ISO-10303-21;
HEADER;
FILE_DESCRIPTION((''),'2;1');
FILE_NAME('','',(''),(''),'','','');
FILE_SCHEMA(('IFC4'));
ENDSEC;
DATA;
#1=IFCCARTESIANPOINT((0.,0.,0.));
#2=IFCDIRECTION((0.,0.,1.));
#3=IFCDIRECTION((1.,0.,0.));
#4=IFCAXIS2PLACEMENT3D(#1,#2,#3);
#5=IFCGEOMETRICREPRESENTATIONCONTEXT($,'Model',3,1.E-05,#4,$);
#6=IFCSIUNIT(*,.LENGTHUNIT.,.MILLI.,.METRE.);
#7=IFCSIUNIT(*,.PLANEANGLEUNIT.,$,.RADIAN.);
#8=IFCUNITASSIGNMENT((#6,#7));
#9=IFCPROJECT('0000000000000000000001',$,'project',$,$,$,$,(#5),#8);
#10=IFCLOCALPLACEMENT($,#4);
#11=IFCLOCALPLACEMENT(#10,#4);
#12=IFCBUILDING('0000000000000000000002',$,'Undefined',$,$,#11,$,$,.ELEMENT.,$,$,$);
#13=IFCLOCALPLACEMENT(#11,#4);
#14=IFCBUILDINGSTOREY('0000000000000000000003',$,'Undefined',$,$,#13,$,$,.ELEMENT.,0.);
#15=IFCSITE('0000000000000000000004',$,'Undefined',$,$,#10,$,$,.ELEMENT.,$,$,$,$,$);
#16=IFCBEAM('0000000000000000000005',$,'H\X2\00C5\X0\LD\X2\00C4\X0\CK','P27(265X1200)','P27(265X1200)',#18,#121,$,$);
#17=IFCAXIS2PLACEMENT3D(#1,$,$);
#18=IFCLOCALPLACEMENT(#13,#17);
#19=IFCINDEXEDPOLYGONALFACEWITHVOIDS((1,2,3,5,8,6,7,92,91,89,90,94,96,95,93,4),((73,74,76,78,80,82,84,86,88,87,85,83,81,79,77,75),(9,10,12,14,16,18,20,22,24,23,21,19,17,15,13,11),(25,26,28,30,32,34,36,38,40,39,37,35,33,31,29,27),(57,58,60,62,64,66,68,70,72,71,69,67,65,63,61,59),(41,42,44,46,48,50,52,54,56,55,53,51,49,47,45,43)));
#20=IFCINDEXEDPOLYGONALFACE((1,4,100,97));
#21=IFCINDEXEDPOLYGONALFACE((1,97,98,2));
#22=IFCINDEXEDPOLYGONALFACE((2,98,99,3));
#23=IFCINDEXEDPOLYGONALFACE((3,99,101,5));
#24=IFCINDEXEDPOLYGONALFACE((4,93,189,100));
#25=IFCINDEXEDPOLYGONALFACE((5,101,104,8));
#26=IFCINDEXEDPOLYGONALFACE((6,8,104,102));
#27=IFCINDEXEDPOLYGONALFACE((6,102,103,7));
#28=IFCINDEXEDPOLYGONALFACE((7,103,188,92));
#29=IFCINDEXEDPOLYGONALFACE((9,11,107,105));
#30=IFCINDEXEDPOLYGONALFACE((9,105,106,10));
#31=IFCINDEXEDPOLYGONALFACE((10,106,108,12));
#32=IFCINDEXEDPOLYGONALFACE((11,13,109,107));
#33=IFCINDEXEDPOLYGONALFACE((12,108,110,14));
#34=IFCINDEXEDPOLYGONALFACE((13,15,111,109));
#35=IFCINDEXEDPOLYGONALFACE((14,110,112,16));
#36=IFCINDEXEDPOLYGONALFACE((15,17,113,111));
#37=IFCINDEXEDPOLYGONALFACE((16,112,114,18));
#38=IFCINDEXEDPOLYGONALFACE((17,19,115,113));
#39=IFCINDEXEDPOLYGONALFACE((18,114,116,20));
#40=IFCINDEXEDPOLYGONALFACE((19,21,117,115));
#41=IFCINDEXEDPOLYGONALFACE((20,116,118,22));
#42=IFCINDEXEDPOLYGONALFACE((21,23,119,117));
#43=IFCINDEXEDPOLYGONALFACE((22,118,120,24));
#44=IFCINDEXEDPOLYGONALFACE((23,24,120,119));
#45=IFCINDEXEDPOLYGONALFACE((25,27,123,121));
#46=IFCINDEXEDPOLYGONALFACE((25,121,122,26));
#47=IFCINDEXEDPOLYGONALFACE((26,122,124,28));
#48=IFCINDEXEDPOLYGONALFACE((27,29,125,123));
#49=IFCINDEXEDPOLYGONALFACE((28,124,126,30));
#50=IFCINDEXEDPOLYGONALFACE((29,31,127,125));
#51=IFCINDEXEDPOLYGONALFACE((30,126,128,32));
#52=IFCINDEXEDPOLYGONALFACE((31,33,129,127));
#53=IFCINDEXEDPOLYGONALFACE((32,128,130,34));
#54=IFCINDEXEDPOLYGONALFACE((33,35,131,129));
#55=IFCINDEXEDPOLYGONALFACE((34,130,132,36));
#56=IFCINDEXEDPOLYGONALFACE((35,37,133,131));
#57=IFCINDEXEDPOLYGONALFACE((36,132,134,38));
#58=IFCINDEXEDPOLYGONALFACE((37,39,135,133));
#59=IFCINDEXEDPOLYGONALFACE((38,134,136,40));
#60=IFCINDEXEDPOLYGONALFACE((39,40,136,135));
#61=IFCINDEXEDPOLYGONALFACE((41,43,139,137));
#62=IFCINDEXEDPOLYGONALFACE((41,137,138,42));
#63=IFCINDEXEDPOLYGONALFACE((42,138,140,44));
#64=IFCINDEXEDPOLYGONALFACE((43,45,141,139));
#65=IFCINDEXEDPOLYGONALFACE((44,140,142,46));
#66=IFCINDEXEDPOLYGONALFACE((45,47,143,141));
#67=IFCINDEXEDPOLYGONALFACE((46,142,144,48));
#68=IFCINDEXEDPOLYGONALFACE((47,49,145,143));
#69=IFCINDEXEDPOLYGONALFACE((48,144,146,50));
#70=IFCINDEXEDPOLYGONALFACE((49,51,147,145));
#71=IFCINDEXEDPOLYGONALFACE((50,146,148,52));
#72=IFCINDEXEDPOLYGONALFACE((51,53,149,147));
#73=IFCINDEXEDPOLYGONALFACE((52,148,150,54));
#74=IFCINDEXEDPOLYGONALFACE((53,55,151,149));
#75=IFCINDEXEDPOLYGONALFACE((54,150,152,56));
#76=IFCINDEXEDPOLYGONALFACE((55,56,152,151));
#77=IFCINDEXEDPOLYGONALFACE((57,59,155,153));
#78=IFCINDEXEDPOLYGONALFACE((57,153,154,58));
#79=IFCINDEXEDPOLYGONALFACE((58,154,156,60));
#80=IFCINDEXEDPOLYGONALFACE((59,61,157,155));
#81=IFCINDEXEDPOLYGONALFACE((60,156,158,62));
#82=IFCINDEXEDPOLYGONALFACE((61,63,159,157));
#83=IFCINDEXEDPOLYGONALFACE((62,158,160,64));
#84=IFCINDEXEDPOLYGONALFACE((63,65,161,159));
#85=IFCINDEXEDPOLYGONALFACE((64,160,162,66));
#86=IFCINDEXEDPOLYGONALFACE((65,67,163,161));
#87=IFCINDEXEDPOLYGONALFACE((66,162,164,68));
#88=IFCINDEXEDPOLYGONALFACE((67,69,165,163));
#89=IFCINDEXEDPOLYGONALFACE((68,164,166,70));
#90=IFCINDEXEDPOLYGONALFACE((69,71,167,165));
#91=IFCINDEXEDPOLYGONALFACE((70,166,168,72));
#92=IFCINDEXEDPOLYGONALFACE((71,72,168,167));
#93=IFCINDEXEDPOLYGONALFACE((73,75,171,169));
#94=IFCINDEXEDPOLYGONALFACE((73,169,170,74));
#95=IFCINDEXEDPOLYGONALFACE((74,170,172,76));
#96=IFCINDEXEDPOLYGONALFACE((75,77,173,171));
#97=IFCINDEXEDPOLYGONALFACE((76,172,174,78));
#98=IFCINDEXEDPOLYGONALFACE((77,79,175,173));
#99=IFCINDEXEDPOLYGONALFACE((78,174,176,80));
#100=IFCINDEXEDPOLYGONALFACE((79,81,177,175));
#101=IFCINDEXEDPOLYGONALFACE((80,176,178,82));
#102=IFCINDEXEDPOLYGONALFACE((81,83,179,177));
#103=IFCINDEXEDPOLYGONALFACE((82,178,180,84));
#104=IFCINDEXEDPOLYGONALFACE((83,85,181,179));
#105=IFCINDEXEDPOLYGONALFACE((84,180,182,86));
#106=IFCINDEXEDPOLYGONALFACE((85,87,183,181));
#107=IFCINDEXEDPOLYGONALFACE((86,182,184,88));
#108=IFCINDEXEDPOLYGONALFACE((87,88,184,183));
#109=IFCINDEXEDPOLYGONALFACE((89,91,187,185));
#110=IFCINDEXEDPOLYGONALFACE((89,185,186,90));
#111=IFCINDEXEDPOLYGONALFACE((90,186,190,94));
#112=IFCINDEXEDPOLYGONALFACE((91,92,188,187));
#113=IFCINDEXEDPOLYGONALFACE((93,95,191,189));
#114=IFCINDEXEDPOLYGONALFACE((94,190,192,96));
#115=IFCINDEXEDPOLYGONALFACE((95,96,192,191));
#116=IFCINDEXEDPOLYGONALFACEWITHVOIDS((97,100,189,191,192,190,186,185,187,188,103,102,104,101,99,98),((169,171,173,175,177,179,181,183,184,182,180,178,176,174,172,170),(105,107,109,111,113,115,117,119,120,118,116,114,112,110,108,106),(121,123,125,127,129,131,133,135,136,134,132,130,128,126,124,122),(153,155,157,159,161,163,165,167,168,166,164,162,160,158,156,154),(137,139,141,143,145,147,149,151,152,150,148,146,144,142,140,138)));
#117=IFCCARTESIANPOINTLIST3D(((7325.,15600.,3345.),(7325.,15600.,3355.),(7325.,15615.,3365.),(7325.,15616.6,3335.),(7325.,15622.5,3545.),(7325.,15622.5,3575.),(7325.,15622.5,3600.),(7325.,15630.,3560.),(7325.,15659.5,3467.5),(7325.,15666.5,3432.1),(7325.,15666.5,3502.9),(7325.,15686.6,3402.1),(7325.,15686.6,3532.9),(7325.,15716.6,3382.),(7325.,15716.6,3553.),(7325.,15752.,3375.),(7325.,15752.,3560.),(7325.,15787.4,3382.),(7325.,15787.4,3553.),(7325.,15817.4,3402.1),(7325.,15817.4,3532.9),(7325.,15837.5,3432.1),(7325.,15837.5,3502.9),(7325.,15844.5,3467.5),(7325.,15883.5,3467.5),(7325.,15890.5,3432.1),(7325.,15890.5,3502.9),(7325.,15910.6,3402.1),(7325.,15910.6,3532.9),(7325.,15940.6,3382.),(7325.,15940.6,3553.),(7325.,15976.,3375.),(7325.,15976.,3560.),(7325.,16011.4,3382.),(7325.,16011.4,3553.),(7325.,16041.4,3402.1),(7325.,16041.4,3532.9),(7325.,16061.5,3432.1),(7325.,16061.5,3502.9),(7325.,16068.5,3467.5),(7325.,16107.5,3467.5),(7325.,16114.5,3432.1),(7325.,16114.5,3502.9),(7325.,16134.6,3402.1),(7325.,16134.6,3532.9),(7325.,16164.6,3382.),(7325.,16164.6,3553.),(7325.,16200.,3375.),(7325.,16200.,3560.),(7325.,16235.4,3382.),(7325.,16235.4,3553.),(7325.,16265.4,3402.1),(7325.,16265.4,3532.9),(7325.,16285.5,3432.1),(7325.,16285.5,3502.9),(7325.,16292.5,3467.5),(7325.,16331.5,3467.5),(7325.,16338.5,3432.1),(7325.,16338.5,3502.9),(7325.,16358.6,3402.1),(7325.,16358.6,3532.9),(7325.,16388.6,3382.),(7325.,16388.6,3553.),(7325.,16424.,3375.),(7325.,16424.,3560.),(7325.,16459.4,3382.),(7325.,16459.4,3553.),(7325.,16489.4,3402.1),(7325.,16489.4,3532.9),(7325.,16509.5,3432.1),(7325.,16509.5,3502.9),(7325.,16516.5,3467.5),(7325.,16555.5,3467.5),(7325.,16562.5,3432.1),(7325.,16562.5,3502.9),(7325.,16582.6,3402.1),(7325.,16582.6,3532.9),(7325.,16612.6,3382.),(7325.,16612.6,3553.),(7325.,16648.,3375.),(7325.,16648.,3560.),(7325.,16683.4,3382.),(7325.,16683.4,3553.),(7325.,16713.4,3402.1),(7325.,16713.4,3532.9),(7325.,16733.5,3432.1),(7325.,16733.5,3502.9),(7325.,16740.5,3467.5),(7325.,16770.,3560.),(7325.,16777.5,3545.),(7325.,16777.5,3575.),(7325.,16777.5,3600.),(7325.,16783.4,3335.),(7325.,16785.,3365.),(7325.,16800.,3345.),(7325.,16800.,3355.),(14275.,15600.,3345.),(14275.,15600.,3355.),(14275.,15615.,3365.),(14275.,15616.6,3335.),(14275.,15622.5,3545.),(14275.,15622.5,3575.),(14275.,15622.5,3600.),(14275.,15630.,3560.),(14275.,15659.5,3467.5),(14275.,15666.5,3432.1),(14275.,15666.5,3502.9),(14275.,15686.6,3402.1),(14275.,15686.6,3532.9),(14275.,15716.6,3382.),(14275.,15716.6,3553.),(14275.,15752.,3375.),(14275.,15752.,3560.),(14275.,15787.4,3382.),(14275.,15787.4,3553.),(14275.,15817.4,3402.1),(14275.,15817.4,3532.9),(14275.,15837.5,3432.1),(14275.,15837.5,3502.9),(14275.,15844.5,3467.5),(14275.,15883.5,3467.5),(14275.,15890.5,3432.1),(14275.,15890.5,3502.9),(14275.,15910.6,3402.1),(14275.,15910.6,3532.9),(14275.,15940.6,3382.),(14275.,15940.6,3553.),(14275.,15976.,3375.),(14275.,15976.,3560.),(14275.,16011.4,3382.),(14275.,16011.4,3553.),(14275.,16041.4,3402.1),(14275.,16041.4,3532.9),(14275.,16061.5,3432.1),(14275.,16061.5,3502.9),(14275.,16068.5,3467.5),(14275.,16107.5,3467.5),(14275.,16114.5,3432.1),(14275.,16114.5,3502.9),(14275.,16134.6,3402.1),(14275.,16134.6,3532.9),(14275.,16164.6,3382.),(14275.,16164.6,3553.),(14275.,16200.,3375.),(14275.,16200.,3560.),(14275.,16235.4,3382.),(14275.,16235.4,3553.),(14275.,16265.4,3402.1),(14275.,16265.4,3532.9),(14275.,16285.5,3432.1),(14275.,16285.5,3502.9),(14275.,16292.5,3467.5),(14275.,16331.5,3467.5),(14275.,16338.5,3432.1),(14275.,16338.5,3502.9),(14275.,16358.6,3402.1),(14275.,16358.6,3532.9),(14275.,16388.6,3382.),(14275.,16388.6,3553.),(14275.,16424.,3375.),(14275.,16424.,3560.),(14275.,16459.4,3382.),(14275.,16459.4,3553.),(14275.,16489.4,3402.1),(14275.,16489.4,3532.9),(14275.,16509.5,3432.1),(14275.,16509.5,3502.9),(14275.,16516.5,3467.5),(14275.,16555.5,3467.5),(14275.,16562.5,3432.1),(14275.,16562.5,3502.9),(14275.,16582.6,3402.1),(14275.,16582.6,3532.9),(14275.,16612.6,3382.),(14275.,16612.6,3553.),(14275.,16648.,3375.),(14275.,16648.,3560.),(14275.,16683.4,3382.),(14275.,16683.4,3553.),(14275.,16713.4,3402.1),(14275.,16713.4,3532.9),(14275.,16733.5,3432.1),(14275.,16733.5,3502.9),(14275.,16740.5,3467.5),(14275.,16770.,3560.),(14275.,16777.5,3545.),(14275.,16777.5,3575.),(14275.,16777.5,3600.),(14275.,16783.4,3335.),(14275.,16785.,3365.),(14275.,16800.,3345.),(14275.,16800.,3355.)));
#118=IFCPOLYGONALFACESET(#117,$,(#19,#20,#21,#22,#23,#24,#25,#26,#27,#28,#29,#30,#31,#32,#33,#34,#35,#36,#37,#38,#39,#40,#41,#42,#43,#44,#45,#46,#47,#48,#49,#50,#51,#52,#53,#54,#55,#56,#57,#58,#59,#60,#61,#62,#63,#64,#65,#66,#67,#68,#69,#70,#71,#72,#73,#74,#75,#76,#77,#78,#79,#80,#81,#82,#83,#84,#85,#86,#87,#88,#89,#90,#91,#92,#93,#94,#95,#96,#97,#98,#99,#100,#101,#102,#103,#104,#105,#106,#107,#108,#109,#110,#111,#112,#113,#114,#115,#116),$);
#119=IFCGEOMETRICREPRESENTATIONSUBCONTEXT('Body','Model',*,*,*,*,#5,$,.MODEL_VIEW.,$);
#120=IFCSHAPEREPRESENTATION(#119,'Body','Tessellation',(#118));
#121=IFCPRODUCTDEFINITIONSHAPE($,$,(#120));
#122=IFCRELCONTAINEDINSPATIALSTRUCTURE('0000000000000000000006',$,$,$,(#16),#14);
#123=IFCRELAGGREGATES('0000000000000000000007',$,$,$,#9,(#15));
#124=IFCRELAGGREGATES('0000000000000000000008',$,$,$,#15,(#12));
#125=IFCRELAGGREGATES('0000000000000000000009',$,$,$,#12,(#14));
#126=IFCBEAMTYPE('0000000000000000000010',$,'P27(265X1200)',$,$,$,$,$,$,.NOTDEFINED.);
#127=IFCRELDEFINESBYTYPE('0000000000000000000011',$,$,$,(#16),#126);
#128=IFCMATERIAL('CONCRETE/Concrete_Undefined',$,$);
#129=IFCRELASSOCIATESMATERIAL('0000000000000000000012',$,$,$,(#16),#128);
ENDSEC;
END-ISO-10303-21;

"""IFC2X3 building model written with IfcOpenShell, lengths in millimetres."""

from ifc_helpers import new_model, si_unit, frame, origin_with_axes, place, context, subcontext, project, spatial, polyline, outline, extrude, material, type_object, element, save


model = new_model("IFC2X3")

# Units and contexts
model_context = context("Model", 3, precision=1e-05, world=origin_with_axes())
body_context = subcontext(model_context, "Body", "Model", "MODEL_VIEW")
ifc_project = project(units=[si_unit("LENGTHUNIT", "METRE", prefix="MILLI"), si_unit("PLANEANGLEUNIT", "RADIAN")], contexts=[model_context])

# Site, building, storey
site_placement = place(None, origin_with_axes())
site = spatial("IfcSite", under=ifc_project, at=site_placement, Name="Undefined", CompositionType="ELEMENT")
building_placement = place(site_placement, origin_with_axes())
building = spatial("IfcBuilding", under=site, at=building_placement, Name="Undefined", CompositionType="ELEMENT")
storey_placement = place(building_placement, origin_with_axes())
storey = spatial("IfcBuildingStorey", under=building, at=storey_placement, Name="Undefined", CompositionType="ELEMENT", Elevation=0.0)

# Beam
ifc_material_1 = material(Name="CONCRETE/Concrete_Undefined")
beam_type_1 = type_object("IfcBeamType", Name="P27(265X1200)", PredefinedType="NOTDEFINED")
beam_1_placement = place(storey_placement, frame((7325.0, 16200.0, 3467.5), z_axis=(0.0, 0.0, 1.0), x_axis=(1.0, 0.0, 0.0)))
element("IfcBeam", 1, at=beam_1_placement, inside=storey, type_object=beam_type_1, material=ifc_material_1, Name="HÅLDÄCK", Description="P27(265X1200)", ObjectType="P27(265X1200)", context=body_context, shape_type="SweptSolid", body=[
    extrude(outline(polyline([(-583.4, -132.5), (-600.0, -122.5), (-600.0, -112.5), (-585.0, -102.5), (-577.5, 77.5), (-570.0, 92.5), (-577.5, 107.5), (-577.5, 132.5), (577.5, 132.5), (577.5, 107.5), (570.0, 92.5), (577.5, 77.5), (585.0, -102.5), (600.0, -112.5), (600.0, -122.5), (583.4, -132.5), (-583.4, -132.5)]), holes=[polyline([(-513.4, 65.4), (-533.5, 35.4), (-540.5, 0.0), (-533.5, -35.4), (-513.4, -65.4), (-483.4, -85.5), (-448.0, -92.5), (-412.6, -85.5), (-382.6, -65.4), (-362.5, -35.4), (-355.5, 0.0), (-362.5, 35.4), (-382.6, 65.4), (-412.6, 85.5), (-448.0, 92.5), (-483.4, 85.5), (-513.4, 65.4)]), polyline([(-289.4, 65.4), (-309.5, 35.4), (-316.5, 0.0), (-309.5, -35.4), (-289.4, -65.4), (-259.4, -85.5), (-224.0, -92.5), (-188.6, -85.5), (-158.6, -65.4), (-138.5, -35.4), (-131.5, 0.0), (-138.5, 35.4), (-158.6, 65.4), (-188.6, 85.5), (-224.0, 92.5), (-259.4, 85.5), (-289.4, 65.4)]), polyline([(-65.4, 65.4), (-85.5, 35.4), (-92.5, 0.0), (-85.5, -35.4), (-65.4, -65.4), (-35.4, -85.5), (0.0, -92.5), (35.4, -85.5), (65.4, -65.4), (85.5, -35.4), (92.5, 0.0), (85.5, 35.4), (65.4, 65.4), (35.4, 85.5), (0.0, 92.5), (-35.4, 85.5), (-65.4, 65.4)]), polyline([(158.6, 65.4), (138.5, 35.4), (131.5, 0.0), (138.5, -35.4), (158.6, -65.4), (188.6, -85.5), (224.0, -92.5), (259.4, -85.5), (289.4, -65.4), (309.5, -35.4), (316.5, 0.0), (309.5, 35.4), (289.4, 65.4), (259.4, 85.5), (224.0, 92.5), (188.6, 85.5), (158.6, 65.4)]), polyline([(382.6, 65.4), (362.5, 35.4), (355.5, 0.0), (362.5, -35.4), (382.6, -65.4), (412.6, -85.5), (448.0, -92.5), (483.4, -85.5), (513.4, -65.4), (533.5, -35.4), (540.5, 0.0), (533.5, 35.4), (513.4, 65.4), (483.4, 85.5), (448.0, 92.5), (412.6, 85.5), (382.6, 65.4)])]), frame((6950.0, 0.0, 0.0), z_axis=(-1.0, 0.0, 0.0), x_axis=(0.0, -1.0, 0.0)), (0.0, 0.0, 1.0), 6950.0),
])

save(model, "model.ifc")
